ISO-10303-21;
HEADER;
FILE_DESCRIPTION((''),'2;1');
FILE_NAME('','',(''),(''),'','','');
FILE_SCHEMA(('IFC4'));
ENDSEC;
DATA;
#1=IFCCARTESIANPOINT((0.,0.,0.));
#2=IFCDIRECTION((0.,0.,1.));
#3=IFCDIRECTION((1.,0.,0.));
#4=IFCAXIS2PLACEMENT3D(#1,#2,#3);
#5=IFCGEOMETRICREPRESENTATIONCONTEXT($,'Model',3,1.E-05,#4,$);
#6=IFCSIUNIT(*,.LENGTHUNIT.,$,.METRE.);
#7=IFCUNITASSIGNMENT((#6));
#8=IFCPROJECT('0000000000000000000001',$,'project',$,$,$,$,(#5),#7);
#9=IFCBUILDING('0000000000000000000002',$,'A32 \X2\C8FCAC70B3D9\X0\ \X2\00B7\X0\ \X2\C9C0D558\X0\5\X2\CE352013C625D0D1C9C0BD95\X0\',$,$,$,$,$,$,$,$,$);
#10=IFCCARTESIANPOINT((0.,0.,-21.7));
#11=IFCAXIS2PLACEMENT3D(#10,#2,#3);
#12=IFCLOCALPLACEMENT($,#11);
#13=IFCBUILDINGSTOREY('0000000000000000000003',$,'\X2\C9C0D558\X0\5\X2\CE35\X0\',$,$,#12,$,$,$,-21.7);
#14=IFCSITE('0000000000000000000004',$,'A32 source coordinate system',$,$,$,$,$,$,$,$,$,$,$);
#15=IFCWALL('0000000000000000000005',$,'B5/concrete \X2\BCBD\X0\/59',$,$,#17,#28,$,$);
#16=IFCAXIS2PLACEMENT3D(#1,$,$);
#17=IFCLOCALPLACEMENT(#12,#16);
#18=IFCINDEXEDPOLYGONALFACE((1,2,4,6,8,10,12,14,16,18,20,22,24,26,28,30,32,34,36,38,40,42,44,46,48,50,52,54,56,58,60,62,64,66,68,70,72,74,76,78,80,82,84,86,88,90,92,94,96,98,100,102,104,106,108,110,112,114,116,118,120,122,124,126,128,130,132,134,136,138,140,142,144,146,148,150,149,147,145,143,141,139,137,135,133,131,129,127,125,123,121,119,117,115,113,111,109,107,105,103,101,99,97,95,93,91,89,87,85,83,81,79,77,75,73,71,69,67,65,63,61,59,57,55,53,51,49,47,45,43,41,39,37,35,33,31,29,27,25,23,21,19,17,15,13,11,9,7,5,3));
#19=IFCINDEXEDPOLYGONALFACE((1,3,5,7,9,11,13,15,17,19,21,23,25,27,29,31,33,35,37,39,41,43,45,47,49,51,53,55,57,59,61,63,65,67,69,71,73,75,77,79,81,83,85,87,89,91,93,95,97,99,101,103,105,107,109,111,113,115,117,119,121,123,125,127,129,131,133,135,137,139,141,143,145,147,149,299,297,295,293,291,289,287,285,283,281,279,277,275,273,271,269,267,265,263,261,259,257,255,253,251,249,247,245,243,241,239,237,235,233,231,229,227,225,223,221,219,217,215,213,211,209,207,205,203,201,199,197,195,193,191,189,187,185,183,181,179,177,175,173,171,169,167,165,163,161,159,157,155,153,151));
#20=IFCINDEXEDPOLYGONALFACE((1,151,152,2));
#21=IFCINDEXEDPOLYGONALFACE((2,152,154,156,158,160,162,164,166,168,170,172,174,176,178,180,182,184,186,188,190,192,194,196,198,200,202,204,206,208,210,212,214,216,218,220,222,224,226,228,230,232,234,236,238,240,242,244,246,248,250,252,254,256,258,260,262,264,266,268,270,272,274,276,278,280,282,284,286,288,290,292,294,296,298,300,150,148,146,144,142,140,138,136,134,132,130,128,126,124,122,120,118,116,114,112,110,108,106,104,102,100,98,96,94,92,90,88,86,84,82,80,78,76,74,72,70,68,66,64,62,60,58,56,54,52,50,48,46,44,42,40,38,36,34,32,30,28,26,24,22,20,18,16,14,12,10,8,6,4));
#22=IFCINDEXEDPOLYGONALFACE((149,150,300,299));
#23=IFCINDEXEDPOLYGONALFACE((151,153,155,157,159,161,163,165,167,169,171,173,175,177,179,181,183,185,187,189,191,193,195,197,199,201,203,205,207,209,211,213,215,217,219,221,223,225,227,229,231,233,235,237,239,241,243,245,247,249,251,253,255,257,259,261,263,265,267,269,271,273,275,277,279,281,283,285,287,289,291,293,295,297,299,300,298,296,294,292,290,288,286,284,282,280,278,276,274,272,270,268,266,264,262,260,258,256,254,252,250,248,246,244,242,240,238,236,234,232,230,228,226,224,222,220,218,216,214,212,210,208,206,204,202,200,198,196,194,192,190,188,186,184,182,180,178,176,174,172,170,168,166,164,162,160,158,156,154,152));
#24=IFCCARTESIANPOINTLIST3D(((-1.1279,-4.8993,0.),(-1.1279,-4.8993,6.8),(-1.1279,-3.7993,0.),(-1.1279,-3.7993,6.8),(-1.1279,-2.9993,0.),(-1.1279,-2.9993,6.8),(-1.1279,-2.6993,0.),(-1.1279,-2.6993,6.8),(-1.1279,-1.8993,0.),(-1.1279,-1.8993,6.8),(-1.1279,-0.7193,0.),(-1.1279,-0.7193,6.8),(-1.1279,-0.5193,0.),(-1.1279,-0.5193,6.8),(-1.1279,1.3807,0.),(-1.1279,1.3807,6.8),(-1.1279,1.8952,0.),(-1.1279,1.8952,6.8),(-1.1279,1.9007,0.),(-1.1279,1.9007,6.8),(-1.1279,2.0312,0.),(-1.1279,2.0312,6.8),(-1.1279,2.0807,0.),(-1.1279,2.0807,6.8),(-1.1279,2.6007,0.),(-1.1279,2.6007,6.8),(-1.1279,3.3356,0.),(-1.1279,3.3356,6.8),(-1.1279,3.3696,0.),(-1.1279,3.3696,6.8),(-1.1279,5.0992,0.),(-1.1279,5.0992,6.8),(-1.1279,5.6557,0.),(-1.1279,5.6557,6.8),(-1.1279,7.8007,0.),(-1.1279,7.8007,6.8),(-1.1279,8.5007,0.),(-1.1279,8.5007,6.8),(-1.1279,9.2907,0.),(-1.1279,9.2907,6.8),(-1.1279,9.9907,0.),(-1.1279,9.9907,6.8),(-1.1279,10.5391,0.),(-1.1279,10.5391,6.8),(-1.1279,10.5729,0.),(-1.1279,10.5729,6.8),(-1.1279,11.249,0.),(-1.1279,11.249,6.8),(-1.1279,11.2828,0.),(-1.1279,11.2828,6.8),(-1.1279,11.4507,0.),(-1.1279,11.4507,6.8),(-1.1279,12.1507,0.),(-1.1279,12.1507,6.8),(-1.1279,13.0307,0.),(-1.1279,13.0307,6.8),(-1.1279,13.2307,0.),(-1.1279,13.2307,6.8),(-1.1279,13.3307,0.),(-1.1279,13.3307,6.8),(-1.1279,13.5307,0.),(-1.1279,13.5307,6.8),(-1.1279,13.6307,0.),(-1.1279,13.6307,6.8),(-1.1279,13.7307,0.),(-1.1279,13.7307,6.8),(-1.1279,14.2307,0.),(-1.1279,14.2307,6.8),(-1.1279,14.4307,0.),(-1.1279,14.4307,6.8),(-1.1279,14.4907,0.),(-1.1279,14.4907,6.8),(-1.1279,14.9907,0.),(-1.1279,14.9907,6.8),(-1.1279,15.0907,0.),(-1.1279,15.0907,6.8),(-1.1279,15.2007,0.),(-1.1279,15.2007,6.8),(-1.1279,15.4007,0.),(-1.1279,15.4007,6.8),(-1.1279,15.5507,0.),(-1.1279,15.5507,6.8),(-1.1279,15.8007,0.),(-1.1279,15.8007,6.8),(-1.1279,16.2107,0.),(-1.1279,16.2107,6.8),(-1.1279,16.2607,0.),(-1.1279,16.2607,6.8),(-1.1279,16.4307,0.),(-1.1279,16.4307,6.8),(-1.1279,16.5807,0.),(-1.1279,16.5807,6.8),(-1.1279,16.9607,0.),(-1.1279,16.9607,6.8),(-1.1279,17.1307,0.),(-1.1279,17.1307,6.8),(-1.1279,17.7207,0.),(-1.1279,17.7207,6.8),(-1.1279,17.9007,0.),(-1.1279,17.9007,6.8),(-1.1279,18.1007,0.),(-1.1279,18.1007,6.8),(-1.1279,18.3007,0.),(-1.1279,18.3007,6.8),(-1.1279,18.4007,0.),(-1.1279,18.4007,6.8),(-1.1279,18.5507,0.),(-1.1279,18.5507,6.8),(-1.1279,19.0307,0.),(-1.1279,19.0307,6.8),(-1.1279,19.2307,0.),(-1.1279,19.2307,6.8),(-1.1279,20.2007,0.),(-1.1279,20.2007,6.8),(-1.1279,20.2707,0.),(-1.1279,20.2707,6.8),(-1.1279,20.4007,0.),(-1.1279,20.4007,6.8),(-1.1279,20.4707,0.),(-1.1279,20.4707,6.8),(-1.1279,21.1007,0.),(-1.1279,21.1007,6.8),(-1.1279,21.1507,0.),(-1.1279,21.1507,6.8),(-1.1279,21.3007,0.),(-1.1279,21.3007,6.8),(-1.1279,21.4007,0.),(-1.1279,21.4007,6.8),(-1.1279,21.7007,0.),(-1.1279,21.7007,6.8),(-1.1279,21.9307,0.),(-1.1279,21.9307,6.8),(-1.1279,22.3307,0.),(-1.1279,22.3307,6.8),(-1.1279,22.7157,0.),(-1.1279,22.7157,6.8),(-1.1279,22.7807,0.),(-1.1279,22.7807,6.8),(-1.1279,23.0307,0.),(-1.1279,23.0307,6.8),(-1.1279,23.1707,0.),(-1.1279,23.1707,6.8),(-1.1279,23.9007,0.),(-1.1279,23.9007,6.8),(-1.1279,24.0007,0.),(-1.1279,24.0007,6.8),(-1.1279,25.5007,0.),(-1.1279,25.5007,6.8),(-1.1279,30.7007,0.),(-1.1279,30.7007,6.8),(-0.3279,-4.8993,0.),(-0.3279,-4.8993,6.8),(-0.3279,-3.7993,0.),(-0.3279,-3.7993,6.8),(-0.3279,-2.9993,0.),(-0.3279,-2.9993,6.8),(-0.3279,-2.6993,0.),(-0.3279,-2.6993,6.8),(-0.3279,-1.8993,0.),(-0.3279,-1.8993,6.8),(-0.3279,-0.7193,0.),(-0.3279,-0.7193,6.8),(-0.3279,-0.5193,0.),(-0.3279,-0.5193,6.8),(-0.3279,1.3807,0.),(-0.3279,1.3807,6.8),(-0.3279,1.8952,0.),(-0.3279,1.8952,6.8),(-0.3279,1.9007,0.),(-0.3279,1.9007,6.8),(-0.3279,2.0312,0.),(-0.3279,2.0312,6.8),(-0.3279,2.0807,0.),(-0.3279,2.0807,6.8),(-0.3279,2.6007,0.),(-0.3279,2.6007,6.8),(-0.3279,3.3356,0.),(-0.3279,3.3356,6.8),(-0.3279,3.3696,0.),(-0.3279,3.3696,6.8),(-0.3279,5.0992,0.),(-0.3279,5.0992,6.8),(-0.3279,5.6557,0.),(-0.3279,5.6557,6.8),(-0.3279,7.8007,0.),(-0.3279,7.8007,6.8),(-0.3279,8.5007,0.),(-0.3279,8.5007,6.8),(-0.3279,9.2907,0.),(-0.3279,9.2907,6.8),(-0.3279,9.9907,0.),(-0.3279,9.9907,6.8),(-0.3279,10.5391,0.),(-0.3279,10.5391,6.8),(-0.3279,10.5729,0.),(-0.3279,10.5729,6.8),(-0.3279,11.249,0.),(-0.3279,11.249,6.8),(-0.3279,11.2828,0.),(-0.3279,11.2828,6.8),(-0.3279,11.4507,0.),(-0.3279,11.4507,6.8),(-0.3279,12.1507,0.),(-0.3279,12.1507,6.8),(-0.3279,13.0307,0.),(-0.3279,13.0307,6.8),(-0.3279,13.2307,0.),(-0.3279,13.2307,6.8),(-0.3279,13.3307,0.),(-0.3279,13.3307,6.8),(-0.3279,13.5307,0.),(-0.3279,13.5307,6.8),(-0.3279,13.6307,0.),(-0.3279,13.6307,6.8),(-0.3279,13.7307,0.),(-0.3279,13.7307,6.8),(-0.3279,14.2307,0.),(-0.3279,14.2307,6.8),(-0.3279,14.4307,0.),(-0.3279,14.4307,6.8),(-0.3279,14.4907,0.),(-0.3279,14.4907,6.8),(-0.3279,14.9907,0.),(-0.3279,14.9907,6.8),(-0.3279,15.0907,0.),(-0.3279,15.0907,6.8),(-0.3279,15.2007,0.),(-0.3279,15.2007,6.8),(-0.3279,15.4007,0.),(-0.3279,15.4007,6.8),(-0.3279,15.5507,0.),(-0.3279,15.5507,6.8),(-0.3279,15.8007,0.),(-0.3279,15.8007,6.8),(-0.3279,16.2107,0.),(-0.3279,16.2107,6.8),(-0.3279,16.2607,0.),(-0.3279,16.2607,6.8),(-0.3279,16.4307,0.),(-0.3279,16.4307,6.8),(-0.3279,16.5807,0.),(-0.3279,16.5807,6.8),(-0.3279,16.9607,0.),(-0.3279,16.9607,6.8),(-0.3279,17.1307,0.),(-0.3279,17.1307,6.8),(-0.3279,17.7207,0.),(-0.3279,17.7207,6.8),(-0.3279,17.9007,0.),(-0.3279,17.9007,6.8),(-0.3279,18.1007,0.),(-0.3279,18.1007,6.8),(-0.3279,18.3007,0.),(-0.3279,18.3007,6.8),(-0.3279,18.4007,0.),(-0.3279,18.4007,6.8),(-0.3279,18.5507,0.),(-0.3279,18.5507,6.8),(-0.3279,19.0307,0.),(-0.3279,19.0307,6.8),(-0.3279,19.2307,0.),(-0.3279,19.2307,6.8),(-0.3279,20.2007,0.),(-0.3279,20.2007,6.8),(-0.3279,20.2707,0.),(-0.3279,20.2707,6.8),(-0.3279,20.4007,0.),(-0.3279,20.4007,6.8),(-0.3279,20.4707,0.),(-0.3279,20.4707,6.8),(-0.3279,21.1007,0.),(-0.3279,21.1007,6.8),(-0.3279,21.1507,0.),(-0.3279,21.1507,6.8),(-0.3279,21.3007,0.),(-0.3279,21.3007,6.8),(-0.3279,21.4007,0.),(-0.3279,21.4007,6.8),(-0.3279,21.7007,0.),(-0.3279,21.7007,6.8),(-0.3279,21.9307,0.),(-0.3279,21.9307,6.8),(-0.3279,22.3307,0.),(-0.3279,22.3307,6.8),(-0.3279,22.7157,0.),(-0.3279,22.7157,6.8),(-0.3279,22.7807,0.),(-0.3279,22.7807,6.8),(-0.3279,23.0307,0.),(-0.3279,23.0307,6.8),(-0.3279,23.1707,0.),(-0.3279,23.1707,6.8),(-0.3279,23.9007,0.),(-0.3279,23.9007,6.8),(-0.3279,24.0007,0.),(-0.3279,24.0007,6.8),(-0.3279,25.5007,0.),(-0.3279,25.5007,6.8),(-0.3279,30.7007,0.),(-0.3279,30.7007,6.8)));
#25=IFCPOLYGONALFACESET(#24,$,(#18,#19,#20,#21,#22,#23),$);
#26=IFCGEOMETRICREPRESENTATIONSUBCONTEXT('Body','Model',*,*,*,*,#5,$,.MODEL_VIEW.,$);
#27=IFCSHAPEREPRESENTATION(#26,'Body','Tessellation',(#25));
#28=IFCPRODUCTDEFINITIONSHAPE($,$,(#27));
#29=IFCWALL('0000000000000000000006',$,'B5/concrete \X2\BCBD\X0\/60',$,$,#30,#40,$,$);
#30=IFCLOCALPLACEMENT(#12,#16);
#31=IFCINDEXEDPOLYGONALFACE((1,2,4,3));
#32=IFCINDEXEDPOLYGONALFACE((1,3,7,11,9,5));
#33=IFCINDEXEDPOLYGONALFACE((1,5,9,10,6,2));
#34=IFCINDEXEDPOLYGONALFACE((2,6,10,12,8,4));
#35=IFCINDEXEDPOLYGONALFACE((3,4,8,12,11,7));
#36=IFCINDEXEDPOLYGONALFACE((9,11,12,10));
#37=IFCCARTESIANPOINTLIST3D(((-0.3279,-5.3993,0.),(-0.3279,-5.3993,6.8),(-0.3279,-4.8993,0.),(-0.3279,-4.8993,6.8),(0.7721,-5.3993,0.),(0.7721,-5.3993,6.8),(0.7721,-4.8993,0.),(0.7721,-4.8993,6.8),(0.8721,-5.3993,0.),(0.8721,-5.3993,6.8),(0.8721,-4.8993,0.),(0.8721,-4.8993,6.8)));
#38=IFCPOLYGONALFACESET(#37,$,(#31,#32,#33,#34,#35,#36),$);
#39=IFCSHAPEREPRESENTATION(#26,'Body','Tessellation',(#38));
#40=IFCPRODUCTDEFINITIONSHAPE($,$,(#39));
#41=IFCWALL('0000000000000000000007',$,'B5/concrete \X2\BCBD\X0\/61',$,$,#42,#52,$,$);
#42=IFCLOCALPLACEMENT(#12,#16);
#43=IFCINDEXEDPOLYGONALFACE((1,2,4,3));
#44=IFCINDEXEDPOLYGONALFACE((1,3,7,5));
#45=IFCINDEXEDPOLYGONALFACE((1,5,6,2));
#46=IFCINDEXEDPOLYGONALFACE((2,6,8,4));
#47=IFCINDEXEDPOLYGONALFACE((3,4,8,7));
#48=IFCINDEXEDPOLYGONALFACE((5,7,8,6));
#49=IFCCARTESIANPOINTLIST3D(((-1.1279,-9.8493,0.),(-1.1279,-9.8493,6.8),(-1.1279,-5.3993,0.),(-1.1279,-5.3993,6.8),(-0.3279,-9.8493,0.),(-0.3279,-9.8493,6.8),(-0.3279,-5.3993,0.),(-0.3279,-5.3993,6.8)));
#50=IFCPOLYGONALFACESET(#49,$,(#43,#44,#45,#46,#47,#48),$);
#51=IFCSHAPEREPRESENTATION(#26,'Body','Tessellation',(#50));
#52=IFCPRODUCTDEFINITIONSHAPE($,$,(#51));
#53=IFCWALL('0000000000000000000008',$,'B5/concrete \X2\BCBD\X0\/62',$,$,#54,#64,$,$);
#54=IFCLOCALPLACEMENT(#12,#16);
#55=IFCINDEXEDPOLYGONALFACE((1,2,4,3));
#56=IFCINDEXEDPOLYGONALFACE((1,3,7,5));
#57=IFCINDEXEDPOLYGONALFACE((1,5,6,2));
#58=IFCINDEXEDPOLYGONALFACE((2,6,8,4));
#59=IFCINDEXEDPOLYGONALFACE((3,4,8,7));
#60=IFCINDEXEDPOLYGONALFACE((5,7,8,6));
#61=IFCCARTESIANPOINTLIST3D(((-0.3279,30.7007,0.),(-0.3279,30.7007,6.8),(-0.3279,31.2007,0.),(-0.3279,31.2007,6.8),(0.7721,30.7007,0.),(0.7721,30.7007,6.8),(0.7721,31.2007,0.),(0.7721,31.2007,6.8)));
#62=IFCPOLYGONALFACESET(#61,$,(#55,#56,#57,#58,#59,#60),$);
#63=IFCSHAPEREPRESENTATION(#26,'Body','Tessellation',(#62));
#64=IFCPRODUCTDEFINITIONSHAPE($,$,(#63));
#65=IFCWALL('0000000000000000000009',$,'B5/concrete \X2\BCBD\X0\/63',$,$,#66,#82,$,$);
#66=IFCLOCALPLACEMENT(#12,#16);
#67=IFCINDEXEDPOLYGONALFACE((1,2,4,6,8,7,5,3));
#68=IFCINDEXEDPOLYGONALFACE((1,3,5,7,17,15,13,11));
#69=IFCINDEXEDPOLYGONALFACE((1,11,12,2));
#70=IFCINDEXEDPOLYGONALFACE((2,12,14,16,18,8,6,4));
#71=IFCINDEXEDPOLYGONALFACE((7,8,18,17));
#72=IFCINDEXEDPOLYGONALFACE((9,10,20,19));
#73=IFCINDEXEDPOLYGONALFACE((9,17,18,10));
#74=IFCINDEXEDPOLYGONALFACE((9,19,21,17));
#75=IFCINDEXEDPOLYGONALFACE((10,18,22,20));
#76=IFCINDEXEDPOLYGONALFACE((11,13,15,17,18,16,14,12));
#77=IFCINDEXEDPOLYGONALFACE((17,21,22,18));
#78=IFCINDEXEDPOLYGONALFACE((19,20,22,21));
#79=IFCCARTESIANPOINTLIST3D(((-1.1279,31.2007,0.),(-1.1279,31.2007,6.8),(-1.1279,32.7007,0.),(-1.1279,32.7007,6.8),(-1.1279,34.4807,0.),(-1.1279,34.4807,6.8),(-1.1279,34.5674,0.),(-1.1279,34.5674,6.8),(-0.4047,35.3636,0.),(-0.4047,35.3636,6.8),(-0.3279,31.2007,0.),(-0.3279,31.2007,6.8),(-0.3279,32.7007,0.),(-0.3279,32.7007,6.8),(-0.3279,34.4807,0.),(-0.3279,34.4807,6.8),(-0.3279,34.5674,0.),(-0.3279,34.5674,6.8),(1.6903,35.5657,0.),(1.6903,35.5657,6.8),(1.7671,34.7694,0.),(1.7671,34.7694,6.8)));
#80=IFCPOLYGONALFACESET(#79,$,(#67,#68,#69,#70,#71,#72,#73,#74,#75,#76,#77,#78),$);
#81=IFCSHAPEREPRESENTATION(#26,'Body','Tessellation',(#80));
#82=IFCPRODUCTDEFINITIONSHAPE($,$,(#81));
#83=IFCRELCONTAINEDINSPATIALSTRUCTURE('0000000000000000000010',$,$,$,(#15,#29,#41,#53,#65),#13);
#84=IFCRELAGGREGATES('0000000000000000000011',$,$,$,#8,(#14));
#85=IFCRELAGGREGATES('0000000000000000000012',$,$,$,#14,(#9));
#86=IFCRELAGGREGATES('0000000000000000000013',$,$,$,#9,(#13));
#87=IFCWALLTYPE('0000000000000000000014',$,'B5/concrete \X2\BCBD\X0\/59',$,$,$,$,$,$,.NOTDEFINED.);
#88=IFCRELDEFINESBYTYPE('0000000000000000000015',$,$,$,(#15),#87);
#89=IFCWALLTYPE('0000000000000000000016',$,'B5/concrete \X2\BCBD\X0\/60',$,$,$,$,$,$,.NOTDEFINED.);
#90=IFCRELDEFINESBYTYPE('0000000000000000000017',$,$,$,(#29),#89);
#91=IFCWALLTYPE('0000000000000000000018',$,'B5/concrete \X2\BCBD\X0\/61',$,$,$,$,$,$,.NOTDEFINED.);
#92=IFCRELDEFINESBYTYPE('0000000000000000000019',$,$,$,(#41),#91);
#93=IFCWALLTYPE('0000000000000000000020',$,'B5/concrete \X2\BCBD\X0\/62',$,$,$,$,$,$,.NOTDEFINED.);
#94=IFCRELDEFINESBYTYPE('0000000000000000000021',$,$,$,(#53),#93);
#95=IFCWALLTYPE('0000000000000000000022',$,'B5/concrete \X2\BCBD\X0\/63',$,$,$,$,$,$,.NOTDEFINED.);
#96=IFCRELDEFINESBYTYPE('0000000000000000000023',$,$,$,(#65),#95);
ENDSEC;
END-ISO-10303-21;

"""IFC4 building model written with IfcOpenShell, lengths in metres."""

from ifc_helpers import new_model, si_unit, frame, origin, origin_with_axes, place, context, subcontext, project, spatial, polyline, outline, extrude, source, transform, mapped, type_object, type_shapes, element, save


model = new_model("IFC4")

# Units and contexts
model_context = context("Model", 3, precision=1e-05, world=origin_with_axes())
body_context = subcontext(model_context, "Body", "Model", "MODEL_VIEW")
ifc_project = project(units=[si_unit("LENGTHUNIT", "METRE")], contexts=[model_context])

# Site, building, storey
site = spatial("IfcSite", under=ifc_project, Name="A32 source coordinate system")
building = spatial("IfcBuilding", under=site, Name="A32 주거동 · 지하5층–옥탑지붕")
storey_placement = place(None, frame((0.0, 0.0, -21.7), z_axis=(0.0, 0.0, 1.0), x_axis=(1.0, 0.0, 0.0)))
storey = spatial("IfcBuildingStorey", under=building, at=storey_placement, Name="지하5층", Elevation=-21.7)

# Walls
wall_type_1 = type_object("IfcWallType", Name="B5/concrete 벽/59", PredefinedType="NOTDEFINED")
shared_shape_1 = source(origin(), body_context, "Body", "SweptSolid", [
    extrude(outline(polyline([(-1.1279, 2.0312), (-1.1279, 2.0807), (-1.1279, 2.6007), (-1.1279, 3.3356), (-1.1279, 3.3696), (-1.1279, 5.0992), (-1.1279, 5.6557), (-1.1279, 7.8007), (-1.1279, 8.5007), (-1.1279, 9.2907), (-1.1279, 9.9907), (-1.1279, 10.5391), (-1.1279, 10.5729), (-1.1279, 11.249), (-1.1279, 11.2828), (-1.1279, 11.4507), (-1.1279, 12.1507), (-1.1279, 13.0307), (-1.1279, 13.2307), (-1.1279, 13.3307), (-1.1279, 13.5307), (-1.1279, 13.6307), (-1.1279, 13.7307), (-1.1279, 14.2307), (-1.1279, 14.4307), (-1.1279, 14.4907), (-1.1279, 14.9907), (-1.1279, 15.0907), (-1.1279, 15.2007), (-1.1279, 15.4007), (-1.1279, 15.5507), (-1.1279, 15.8007), (-1.1279, 16.2107), (-1.1279, 16.2607), (-1.1279, 16.4307), (-1.1279, 16.5807), (-1.1279, 16.9607), (-1.1279, 17.1307), (-1.1279, 17.7207), (-1.1279, 17.9007), (-1.1279, 18.1007), (-1.1279, 18.3007), (-1.1279, 18.4007), (-1.1279, 18.5507), (-1.1279, 19.0307), (-1.1279, 19.2307), (-1.1279, 20.2007), (-1.1279, 20.2707), (-1.1279, 20.4007), (-1.1279, 20.4707), (-1.1279, 21.1007), (-1.1279, 21.1507), (-1.1279, 21.3007), (-1.1279, 21.4007), (-1.1279, 21.7007), (-1.1279, 21.9307), (-1.1279, 22.3307), (-1.1279, 22.7157), (-1.1279, 22.7807), (-1.1279, 23.0307), (-1.1279, 23.1707), (-1.1279, 23.9007), (-1.1279, 24.0007), (-1.1279, 25.5007), (-1.1279, 30.7007), (-0.3279, 30.7007), (-0.3279, 25.5007), (-0.3279, 24.0007), (-0.3279, 23.9007), (-0.3279, 23.1707), (-0.3279, 23.0307), (-0.3279, 22.7807), (-0.3279, 22.7157), (-0.3279, 22.3307), (-0.3279, 21.9307), (-0.3279, 21.7007), (-0.3279, 21.4007), (-0.3279, 21.3007), (-0.3279, 21.1507), (-0.3279, 21.1007), (-0.3279, 20.4707), (-0.3279, 20.4007), (-0.3279, 20.2707), (-0.3279, 20.2007), (-0.3279, 19.2307), (-0.3279, 19.0307), (-0.3279, 18.5507), (-0.3279, 18.4007), (-0.3279, 18.3007), (-0.3279, 18.1007), (-0.3279, 17.9007), (-0.3279, 17.7207), (-0.3279, 17.1307), (-0.3279, 16.9607), (-0.3279, 16.5807), (-0.3279, 16.4307), (-0.3279, 16.2607), (-0.3279, 16.2107), (-0.3279, 15.8007), (-0.3279, 15.5507), (-0.3279, 15.4007), (-0.3279, 15.2007), (-0.3279, 15.0907), (-0.3279, 14.9907), (-0.3279, 14.4907), (-0.3279, 14.4307), (-0.3279, 14.2307), (-0.3279, 13.7307), (-0.3279, 13.6307), (-0.3279, 13.5307), (-0.3279, 13.3307), (-0.3279, 13.2307), (-0.3279, 13.0307), (-0.3279, 12.1507), (-0.3279, 11.4507), (-0.3279, 11.2828), (-0.3279, 11.249), (-0.3279, 10.5729), (-0.3279, 10.5391), (-0.3279, 9.9907), (-0.3279, 9.2907), (-0.3279, 8.5007), (-0.3279, 7.8007), (-0.3279, 5.6557), (-0.3279, 5.0992), (-0.3279, 3.3696), (-0.3279, 3.3356), (-0.3279, 2.6007), (-0.3279, 2.0807), (-0.3279, 2.0312), (-0.3279, 1.9007), (-0.3279, 1.8952), (-0.3279, 1.3807), (-0.3279, -0.5193), (-0.3279, -0.7193), (-0.3279, -1.8993), (-0.3279, -2.6993), (-0.3279, -2.9993), (-0.3279, -3.7993), (-0.3279, -4.8993), (-1.1279, -4.8993), (-1.1279, -3.7993), (-1.1279, -2.9993), (-1.1279, -2.6993), (-1.1279, -1.8993), (-1.1279, -0.7193), (-1.1279, -0.5193), (-1.1279, 1.3807), (-1.1279, 1.8952), (-1.1279, 1.9007), (-1.1279, 2.0312)])), origin(), (0.0, 0.0, 1.0), 6.8),
])
type_shapes(wall_type_1, [shared_shape_1])
wall_1_placement = place(storey_placement, origin_with_axes())
element("IfcWall", 1, at=wall_1_placement, inside=storey, type_object=wall_type_1, Name="B5/concrete 벽/59", context=body_context, shape_type="MappedRepresentation", body=[
    mapped(shared_shape_1, transform((0.0, 0.0, 0.0), scale=1.0)),
])
wall_type_2 = type_object("IfcWallType", Name="B5/concrete 벽/60", PredefinedType="NOTDEFINED")
shared_shape_2 = source(origin(), body_context, "Body", "SweptSolid", [
    extrude(outline(polyline([(0.8721, -5.3993), (0.7721, -5.3993), (-0.3279, -5.3993), (-0.3279, -4.8993), (0.7721, -4.8993), (0.8721, -4.8993), (0.8721, -5.3993)])), origin(), (0.0, 0.0, 1.0), 6.8),
])
type_shapes(wall_type_2, [shared_shape_2])
wall_2_placement = place(storey_placement, origin_with_axes())
element("IfcWall", 2, at=wall_2_placement, inside=storey, type_object=wall_type_2, Name="B5/concrete 벽/60", context=body_context, shape_type="MappedRepresentation", body=[
    mapped(shared_shape_2, transform((0.0, 0.0, 0.0), scale=1.0)),
])
wall_type_3 = type_object("IfcWallType", Name="B5/concrete 벽/61", PredefinedType="NOTDEFINED")
shared_shape_3 = source(origin(), body_context, "Body", "SweptSolid", [
    extrude(outline(polyline([(-1.1279, -5.3993), (-0.3279, -5.3993), (-0.3279, -9.8493), (-1.1279, -9.8493), (-1.1279, -5.3993)])), origin(), (0.0, 0.0, 1.0), 6.8),
])
type_shapes(wall_type_3, [shared_shape_3])
wall_3_placement = place(storey_placement, origin_with_axes())
element("IfcWall", 3, at=wall_3_placement, inside=storey, type_object=wall_type_3, Name="B5/concrete 벽/61", context=body_context, shape_type="MappedRepresentation", body=[
    mapped(shared_shape_3, transform((0.0, 0.0, 0.0), scale=1.0)),
])
wall_type_4 = type_object("IfcWallType", Name="B5/concrete 벽/62", PredefinedType="NOTDEFINED")
shared_shape_4 = source(origin(), body_context, "Body", "SweptSolid", [
    extrude(outline(polyline([(0.7721, 30.7007), (-0.3279, 30.7007), (-0.3279, 31.2007), (0.7721, 31.2007), (0.7721, 30.7007)])), origin(), (0.0, 0.0, 1.0), 6.8),
])
type_shapes(wall_type_4, [shared_shape_4])
wall_4_placement = place(storey_placement, origin_with_axes())
element("IfcWall", 4, at=wall_4_placement, inside=storey, type_object=wall_type_4, Name="B5/concrete 벽/62", context=body_context, shape_type="MappedRepresentation", body=[
    mapped(shared_shape_4, transform((0.0, 0.0, 0.0), scale=1.0)),
])
wall_type_5 = type_object("IfcWallType", Name="B5/concrete 벽/63", PredefinedType="NOTDEFINED")
shared_shape_5 = source(origin(), body_context, "Body", "SweptSolid", [
    extrude(outline(polyline([(-1.1279, 34.4807), (-1.1279, 34.5674), (-0.3279, 34.5674), (-0.4047, 35.3636), (1.6903, 35.5657), (1.7671, 34.7694), (-0.3279, 34.5674), (-0.3279, 34.5674), (-0.3279, 34.4807), (-0.3279, 32.7007), (-0.3279, 31.2007), (-1.1279, 31.2007), (-1.1279, 32.7007), (-1.1279, 34.4807)])), origin(), (0.0, 0.0, 1.0), 6.8),
])
type_shapes(wall_type_5, [shared_shape_5])
wall_5_placement = place(storey_placement, origin_with_axes())
element("IfcWall", 5, at=wall_5_placement, inside=storey, type_object=wall_type_5, Name="B5/concrete 벽/63", context=body_context, shape_type="MappedRepresentation", body=[
    mapped(shared_shape_5, transform((0.0, 0.0, 0.0), scale=1.0)),
])

save(model, "model.ifc")
